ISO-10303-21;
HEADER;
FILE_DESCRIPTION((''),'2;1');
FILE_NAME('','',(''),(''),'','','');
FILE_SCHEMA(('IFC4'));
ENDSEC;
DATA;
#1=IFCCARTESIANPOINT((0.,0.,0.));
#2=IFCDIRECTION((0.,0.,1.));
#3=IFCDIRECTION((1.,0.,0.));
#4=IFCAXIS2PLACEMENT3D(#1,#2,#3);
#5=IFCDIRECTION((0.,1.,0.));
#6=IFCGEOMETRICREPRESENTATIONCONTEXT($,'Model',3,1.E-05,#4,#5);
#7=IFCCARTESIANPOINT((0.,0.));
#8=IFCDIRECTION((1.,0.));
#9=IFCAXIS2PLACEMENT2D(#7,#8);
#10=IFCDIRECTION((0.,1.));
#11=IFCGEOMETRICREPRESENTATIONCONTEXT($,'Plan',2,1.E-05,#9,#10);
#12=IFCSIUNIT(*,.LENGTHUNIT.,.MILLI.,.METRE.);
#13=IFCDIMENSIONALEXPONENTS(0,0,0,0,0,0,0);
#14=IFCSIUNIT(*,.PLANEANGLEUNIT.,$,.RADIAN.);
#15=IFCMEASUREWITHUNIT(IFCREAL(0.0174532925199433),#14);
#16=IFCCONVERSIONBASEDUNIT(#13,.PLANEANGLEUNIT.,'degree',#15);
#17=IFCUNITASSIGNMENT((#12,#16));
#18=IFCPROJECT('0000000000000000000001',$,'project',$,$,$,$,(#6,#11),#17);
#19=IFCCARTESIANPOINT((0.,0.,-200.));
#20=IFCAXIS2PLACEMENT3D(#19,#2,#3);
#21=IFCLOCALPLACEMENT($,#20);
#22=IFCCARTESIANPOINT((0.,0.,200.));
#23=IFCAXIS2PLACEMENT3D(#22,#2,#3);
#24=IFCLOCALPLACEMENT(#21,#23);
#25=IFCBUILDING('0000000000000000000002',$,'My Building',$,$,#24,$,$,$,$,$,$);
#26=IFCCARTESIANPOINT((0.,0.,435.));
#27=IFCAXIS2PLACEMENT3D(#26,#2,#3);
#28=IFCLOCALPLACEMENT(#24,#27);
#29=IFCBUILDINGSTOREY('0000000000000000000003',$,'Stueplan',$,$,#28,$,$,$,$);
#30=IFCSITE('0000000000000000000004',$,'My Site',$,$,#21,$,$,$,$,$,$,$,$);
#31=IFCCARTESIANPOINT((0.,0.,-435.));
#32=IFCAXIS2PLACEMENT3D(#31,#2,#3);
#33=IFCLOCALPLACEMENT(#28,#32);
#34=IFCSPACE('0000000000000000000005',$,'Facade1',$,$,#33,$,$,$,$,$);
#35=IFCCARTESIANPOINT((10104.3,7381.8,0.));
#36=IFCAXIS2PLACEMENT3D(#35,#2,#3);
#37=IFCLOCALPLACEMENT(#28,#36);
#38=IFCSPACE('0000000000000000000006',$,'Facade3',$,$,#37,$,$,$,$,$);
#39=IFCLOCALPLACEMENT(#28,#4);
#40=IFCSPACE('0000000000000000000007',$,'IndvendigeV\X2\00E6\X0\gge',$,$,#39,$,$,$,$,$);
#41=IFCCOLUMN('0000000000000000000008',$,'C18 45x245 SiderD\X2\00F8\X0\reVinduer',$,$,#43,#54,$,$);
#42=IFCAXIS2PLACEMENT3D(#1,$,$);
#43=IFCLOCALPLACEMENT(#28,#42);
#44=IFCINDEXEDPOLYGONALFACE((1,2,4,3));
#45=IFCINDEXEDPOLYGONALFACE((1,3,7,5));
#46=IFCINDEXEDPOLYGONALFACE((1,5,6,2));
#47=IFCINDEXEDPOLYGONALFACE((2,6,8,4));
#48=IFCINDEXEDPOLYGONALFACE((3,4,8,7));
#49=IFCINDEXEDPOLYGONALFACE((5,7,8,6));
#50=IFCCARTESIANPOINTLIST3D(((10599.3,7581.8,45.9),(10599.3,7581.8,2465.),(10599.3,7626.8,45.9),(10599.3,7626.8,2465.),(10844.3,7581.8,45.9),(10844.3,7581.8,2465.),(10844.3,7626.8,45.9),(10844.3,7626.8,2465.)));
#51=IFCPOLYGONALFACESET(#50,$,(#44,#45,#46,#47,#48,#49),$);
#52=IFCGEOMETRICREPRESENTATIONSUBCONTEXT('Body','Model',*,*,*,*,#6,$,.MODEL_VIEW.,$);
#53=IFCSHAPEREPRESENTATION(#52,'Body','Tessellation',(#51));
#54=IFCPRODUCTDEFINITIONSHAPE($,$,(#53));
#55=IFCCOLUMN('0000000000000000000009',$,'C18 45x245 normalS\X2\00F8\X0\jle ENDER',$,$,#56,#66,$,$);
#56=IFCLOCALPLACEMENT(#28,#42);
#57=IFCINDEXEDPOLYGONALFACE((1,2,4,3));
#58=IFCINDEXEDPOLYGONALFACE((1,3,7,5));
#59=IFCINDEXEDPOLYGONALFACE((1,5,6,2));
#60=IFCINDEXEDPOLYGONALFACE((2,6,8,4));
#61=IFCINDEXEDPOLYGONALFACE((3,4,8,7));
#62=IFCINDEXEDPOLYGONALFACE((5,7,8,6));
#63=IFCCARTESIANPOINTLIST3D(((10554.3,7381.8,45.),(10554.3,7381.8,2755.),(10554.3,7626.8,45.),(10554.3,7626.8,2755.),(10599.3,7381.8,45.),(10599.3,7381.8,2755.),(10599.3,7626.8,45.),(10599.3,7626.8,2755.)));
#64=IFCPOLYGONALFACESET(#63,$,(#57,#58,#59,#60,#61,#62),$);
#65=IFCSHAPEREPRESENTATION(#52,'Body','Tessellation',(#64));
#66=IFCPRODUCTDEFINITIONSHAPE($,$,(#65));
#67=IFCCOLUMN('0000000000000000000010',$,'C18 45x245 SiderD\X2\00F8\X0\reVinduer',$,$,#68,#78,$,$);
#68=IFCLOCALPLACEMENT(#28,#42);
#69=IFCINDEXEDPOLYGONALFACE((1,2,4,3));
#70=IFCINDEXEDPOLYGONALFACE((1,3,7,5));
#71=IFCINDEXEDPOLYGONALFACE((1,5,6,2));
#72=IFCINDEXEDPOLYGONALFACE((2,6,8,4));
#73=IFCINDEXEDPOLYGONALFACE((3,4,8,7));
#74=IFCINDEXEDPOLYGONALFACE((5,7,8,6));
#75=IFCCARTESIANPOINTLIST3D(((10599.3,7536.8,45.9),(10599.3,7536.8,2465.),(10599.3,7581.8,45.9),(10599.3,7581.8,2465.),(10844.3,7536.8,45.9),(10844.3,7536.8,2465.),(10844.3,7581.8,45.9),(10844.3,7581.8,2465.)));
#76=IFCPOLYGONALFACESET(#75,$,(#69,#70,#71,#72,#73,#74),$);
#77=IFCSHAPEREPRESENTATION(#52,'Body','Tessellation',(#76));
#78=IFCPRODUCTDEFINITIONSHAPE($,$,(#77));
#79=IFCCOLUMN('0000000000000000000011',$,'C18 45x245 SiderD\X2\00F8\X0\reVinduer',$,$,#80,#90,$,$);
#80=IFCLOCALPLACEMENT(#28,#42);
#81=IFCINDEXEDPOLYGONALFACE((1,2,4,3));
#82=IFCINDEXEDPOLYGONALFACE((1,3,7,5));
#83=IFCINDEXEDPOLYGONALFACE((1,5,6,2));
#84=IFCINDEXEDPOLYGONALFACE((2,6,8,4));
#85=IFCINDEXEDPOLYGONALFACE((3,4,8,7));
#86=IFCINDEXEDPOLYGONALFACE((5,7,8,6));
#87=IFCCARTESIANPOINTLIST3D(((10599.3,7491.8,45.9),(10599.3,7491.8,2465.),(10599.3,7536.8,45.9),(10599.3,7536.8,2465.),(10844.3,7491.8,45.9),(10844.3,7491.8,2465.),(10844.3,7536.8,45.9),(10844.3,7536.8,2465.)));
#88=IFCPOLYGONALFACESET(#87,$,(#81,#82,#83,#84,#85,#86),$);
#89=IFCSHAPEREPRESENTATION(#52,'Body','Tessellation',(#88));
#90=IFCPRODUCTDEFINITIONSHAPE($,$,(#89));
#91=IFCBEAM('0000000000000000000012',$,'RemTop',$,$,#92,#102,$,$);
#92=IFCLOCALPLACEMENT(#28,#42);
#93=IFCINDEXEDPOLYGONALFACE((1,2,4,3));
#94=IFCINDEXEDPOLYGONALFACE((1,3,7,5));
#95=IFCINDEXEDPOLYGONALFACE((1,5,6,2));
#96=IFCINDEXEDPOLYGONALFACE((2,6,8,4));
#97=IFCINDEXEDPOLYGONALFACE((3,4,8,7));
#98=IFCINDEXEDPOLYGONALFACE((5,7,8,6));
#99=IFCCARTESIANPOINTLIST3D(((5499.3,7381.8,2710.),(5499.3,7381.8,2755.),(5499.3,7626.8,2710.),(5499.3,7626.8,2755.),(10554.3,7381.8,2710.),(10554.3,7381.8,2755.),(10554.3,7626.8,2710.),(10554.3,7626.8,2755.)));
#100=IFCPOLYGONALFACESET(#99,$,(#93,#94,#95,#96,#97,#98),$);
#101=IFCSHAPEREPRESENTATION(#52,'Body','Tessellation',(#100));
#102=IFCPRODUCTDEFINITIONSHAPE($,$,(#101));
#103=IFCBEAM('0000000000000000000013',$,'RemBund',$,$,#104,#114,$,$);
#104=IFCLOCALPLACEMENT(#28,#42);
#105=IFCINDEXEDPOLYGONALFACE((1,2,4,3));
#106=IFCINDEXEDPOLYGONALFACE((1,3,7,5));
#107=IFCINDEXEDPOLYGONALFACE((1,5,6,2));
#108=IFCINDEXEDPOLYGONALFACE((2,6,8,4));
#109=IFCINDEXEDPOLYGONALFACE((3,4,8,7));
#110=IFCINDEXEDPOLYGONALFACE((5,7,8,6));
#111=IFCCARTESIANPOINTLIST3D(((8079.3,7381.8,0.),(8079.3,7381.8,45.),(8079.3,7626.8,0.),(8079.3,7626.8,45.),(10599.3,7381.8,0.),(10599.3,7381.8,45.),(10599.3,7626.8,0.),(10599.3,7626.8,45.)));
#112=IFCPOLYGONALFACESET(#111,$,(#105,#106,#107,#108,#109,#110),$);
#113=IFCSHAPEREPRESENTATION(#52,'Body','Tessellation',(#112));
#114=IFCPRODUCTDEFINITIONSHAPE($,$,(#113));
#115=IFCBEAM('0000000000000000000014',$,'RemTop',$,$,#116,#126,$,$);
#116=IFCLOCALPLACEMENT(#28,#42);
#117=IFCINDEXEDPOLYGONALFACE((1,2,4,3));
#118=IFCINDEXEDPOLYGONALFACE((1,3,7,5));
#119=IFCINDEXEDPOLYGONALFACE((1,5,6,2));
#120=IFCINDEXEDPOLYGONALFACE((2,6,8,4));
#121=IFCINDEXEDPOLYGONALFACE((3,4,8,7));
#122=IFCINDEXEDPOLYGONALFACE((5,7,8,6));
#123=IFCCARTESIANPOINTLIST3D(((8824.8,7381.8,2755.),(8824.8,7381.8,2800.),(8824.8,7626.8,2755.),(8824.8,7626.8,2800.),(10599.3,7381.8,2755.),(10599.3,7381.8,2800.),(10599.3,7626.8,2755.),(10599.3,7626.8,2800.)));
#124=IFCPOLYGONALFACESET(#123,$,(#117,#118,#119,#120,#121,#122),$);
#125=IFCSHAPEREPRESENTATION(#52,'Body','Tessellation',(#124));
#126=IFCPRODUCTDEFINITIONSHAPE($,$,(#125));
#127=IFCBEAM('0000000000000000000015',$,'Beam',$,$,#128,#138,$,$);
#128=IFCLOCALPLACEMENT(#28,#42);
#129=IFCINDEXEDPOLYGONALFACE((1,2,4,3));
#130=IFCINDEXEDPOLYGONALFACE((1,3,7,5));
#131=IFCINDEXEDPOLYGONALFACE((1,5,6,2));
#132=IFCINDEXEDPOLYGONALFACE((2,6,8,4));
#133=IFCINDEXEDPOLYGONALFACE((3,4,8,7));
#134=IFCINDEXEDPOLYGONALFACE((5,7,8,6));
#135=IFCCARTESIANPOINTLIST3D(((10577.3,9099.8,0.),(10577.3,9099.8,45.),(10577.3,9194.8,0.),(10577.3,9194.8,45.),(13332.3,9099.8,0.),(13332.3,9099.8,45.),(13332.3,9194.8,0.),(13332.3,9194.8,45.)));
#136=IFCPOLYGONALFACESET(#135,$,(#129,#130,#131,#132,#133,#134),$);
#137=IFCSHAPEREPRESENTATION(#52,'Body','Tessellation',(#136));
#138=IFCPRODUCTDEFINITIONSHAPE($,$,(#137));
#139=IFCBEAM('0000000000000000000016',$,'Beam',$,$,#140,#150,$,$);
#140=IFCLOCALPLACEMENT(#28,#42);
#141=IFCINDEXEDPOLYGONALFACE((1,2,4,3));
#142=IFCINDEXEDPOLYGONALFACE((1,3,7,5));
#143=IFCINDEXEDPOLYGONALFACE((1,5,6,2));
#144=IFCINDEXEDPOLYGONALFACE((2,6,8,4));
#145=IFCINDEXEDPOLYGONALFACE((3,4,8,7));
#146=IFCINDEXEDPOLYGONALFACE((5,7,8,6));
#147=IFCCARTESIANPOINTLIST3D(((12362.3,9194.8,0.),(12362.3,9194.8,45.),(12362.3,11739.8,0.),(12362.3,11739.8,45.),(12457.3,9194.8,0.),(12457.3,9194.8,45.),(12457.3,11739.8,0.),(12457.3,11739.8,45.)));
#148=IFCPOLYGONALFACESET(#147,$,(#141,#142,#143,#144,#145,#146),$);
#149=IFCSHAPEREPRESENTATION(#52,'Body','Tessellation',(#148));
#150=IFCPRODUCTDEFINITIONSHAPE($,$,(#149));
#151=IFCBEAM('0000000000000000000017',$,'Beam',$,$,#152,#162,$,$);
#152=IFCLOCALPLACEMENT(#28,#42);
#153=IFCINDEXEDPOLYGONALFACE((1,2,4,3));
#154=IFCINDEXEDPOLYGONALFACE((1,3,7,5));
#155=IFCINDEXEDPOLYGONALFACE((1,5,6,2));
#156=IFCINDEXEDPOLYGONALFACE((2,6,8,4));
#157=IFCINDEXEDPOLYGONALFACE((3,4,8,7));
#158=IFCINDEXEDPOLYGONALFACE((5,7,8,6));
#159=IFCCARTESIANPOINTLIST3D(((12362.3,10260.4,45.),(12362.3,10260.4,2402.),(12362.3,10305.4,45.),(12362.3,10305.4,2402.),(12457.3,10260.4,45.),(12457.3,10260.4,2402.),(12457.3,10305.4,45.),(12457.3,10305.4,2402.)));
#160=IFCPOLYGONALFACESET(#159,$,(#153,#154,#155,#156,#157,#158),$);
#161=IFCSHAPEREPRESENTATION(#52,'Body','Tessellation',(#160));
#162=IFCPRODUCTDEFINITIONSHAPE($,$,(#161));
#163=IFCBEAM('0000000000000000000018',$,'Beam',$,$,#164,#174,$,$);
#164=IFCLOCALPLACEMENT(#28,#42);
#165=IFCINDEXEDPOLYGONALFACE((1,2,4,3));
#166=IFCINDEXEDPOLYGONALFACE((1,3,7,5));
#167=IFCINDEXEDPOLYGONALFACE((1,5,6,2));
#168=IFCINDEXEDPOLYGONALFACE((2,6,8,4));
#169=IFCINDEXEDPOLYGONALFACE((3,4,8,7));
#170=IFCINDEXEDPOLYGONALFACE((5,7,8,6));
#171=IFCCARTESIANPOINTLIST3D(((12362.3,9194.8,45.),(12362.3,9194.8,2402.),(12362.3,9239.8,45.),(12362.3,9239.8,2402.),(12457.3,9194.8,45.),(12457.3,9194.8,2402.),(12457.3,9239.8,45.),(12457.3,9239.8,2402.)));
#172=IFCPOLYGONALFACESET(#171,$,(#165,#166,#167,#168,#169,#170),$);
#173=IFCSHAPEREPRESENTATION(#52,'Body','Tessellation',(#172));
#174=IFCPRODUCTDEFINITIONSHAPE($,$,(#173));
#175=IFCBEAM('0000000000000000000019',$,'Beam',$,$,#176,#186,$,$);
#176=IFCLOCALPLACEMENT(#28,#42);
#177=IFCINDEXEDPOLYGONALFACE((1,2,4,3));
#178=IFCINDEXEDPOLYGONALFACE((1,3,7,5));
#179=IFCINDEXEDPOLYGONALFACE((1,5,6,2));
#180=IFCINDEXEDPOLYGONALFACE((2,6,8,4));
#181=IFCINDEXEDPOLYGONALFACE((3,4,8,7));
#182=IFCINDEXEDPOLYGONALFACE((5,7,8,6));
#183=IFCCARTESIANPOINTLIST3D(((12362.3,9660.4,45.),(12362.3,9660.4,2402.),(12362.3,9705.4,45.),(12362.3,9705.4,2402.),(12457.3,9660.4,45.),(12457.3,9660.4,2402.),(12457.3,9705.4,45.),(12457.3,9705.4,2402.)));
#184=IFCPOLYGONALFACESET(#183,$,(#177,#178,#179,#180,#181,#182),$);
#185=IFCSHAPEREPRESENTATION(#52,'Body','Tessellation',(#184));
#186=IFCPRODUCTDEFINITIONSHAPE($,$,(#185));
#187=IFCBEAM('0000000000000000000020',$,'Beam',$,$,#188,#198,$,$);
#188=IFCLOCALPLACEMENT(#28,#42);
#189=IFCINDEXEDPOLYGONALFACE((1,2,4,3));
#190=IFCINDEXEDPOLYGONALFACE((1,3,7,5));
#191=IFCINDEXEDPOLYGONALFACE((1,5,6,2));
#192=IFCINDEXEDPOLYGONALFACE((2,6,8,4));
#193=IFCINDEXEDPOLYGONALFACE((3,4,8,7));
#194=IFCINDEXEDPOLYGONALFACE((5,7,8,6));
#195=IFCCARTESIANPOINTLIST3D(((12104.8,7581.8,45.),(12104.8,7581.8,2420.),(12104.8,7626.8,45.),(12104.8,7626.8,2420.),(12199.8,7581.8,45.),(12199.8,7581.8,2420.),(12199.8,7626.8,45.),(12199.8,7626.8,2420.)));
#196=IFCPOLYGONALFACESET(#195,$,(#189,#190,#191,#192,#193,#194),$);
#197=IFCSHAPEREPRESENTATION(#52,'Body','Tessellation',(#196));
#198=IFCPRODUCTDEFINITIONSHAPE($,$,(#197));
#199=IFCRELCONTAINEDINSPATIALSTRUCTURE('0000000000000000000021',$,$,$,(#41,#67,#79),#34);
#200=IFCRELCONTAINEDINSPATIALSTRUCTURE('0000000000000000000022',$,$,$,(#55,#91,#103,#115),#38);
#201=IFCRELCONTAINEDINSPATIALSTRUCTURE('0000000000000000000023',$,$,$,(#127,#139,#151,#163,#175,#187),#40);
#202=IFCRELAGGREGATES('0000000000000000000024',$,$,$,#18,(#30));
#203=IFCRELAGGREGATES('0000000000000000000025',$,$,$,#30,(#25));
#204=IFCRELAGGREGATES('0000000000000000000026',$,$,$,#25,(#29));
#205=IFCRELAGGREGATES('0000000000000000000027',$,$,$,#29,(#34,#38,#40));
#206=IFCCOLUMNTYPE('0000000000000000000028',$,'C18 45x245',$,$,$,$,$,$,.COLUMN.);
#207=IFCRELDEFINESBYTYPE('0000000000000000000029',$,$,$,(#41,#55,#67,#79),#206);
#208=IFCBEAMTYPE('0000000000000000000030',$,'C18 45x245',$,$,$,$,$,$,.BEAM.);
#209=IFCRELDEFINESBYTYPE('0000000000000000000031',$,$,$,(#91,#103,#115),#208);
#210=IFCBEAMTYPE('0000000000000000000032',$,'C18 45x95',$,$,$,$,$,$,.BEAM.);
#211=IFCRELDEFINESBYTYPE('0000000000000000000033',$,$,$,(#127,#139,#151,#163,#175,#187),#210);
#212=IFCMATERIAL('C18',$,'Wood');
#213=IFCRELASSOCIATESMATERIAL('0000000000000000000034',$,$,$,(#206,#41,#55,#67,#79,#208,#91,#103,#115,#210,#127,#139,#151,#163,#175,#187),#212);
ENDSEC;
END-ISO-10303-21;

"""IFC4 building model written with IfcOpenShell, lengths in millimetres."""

from ifc_helpers import new_model, entity, si_unit, converted_unit, direction, frame, origin_with_axes, origin_2d_with_axis, place, context, subcontext, project, spatial, rectangle, extrude, material, material_profile, profile_set, profile_usage, type_object, element, save


model = new_model("IFC4")

# Units and contexts
model_context = context("Model", 3, precision=1e-05, world=origin_with_axes(), true_north=direction((0.0, 1.0, 0.0)))
plan_context = context("Plan", 2, precision=1e-05, world=origin_2d_with_axis(), true_north=direction((0.0, 1.0)))
body_context_1 = subcontext(model_context, "Body", "Model", "MODEL_VIEW")
ifc_project = project(units=[si_unit("LENGTHUNIT", "METRE", prefix="MILLI"), converted_unit("PLANEANGLEUNIT", "degree", entity("IfcReal", 0.0174532925199433), si_unit("PLANEANGLEUNIT", "RADIAN"), dimensions=[0, 0, 0, 0, 0, 0, 0])], contexts=[model_context, plan_context])

# Site, building, storey, space
site_placement = place(None, frame((0.0, 0.0, -200.0), z_axis=(0.0, 0.0, 1.0), x_axis=(1.0, 0.0, 0.0)))
site = spatial("IfcSite", under=ifc_project, at=site_placement, Name="My Site")
building_placement = place(site_placement, frame((0.0, 0.0, 200.0), z_axis=(0.0, 0.0, 1.0), x_axis=(1.0, 0.0, 0.0)))
building = spatial("IfcBuilding", under=site, at=building_placement, Name="My Building")
storey_placement = place(building_placement, frame((0.0, 0.0, 435.0), z_axis=(0.0, 0.0, 1.0), x_axis=(1.0, 0.0, 0.0)))
storey = spatial("IfcBuildingStorey", under=building, at=storey_placement, Name="Stueplan")
space_1_placement = place(storey_placement, frame((0.0, 0.0, -435.0), z_axis=(0.0, 0.0, 1.0), x_axis=(1.0, 0.0, 0.0)))
space_1 = spatial("IfcSpace", under=storey, at=space_1_placement, Name="Facade1")

# Column
ifc_material = material(Name="C18", Category="Wood")
ifc_material_profile_1 = material_profile(ifc_material, rectangle(XDim=45.0, YDim=245.0))
ifc_profile_set_1 = profile_set([ifc_material_profile_1], Name="woodStructural")
ifc_profile_usage_1 = profile_usage(ifc_profile_set_1, cardinal=9)
column_type = type_object("IfcColumnType", Name="C18 45x245", PredefinedType="COLUMN", material=ifc_profile_set_1)
column_1_placement = place(space_1_placement, frame((10844.3, 7626.8, 480.9), z_axis=(0.0, 0.0, 1.0), x_axis=(0.0, -1.0, 0.0)))
element("IfcColumn", 1, at=column_1_placement, inside=space_1, type_object=column_type, material=ifc_profile_usage_1, Name="C18 45x245 SiderDøreVinduer", context=body_context_1, shape_type="SweptSolid", body=[
    extrude(rectangle(XDim=45.0, YDim=245.0), frame((22.5, -122.5, 0.0), z_axis=(0.0, 0.0, 1.0), x_axis=(1.0, 0.0, 0.0)), (0.0, 0.0, 1.0), 2419.1),
])

# Shared definitions
space_2_placement = place(storey_placement, frame((10104.3, 7381.8, 0.0), z_axis=(0.0, 0.0, 1.0), x_axis=(1.0, 0.0, 0.0)))
space_2 = spatial("IfcSpace", under=storey, at=space_2_placement, Name="Facade3")

# Columns
ifc_profile_usage_2 = profile_usage(ifc_profile_set_1, cardinal=9)
column_2_placement = place(space_2_placement, frame((449.9, 245.0, 45.0), z_axis=(0.0, 0.0, 1.0), x_axis=(1.0, 0.0, 0.0)))
element("IfcColumn", 2, at=column_2_placement, inside=space_2, type_object=column_type, material=ifc_profile_usage_2, Name="C18 45x245 normalSøjle ENDER", context=body_context_1, shape_type="SweptSolid", body=[
    extrude(rectangle(XDim=45.0, YDim=245.0), frame((22.5, -122.5, 0.0), z_axis=(0.0, 0.0, 1.0), x_axis=(1.0, 0.0, 0.0)), (0.0, 0.0, 1.0), 2710.0),
])
ifc_profile_usage_3 = profile_usage(ifc_profile_set_1, cardinal=9)
column_3_placement = place(space_1_placement, frame((10844.3, 7581.8, 480.9), z_axis=(0.0, 0.0, 1.0), x_axis=(0.0, -1.0, 0.0)))
element("IfcColumn", 3, at=column_3_placement, inside=space_1, type_object=column_type, material=ifc_profile_usage_3, Name="C18 45x245 SiderDøreVinduer", context=body_context_1, shape_type="SweptSolid", body=[
    extrude(rectangle(XDim=45.0, YDim=245.0), frame((22.5, -122.5, 0.0), z_axis=(0.0, 0.0, 1.0), x_axis=(1.0, 0.0, 0.0)), (0.0, 0.0, 1.0), 2419.1),
])
ifc_profile_usage_4 = profile_usage(ifc_profile_set_1, cardinal=9)
column_4_placement = place(space_1_placement, frame((10844.3, 7536.8, 480.9), z_axis=(0.0, 0.0, 1.0), x_axis=(0.0, -1.0, 0.0)))
element("IfcColumn", 4, at=column_4_placement, inside=space_1, type_object=column_type, material=ifc_profile_usage_4, Name="C18 45x245 SiderDøreVinduer", context=body_context_1, shape_type="SweptSolid", body=[
    extrude(rectangle(XDim=45.0, YDim=245.0), frame((22.5, -122.5, 0.0), z_axis=(0.0, 0.0, 1.0), x_axis=(1.0, 0.0, 0.0)), (0.0, 0.0, 1.0), 2419.1),
])

# Beams
ifc_material_profile_2 = material_profile(ifc_material, rectangle(XDim=45.0, YDim=245.0), Name="concrete")
ifc_profile_set_2 = profile_set([ifc_material_profile_2], Name="woodStructural")
ifc_profile_usage_5 = profile_usage(ifc_profile_set_2)
beam_type_1 = type_object("IfcBeamType", Name="C18 45x245", PredefinedType="BEAM", material=ifc_profile_set_2)
beam_1_placement = place(space_2_placement, frame((449.9, 122.5, 2732.5), z_axis=(-1.0, 0.0, 0.0), x_axis=(0.0, 0.0, 1.0)))
element("IfcBeam", 5, at=beam_1_placement, inside=space_2, type_object=beam_type_1, material=ifc_profile_usage_5, Name="RemTop", context=body_context_1, shape_type="SweptSolid", body=[
    extrude(rectangle(XDim=45.0, YDim=245.0), origin_with_axes(), (0.0, 0.0, 1.0), 5055.0),
])
ifc_profile_usage_6 = profile_usage(ifc_profile_set_2)
beam_2_placement = place(space_2_placement, frame((494.9, 122.5, 22.5), z_axis=(-1.0, 0.0, 0.0), x_axis=(0.0, 0.0, 1.0)))
element("IfcBeam", 6, at=beam_2_placement, inside=space_2, type_object=beam_type_1, material=ifc_profile_usage_6, Name="RemBund", context=body_context_1, shape_type="SweptSolid", body=[
    extrude(rectangle(XDim=45.0, YDim=245.0), origin_with_axes(), (0.0, 0.0, 1.0), 2520.0),
])
ifc_profile_usage_7 = profile_usage(ifc_profile_set_2)
beam_3_placement = place(space_2_placement, frame((494.9, 122.5, 2777.5), z_axis=(-1.0, 0.0, 0.0), x_axis=(0.0, 0.0, 1.0)))
element("IfcBeam", 7, at=beam_3_placement, inside=space_2, type_object=beam_type_1, material=ifc_profile_usage_7, Name="RemTop", context=body_context_1, shape_type="SweptSolid", body=[
    extrude(rectangle(XDim=45.0, YDim=245.0), origin_with_axes(), (0.0, 0.0, 1.0), 1774.5),
])

# Shared definitions
space_3_placement = place(storey_placement, frame((0.0, 0.0, 0.0), z_axis=(0.0, 0.0, 1.0), x_axis=(1.0, 0.0, 0.0)))
space_3 = spatial("IfcSpace", under=storey, at=space_3_placement, Name="IndvendigeVægge")

# Beams
ifc_material_profile_3 = material_profile(ifc_material, rectangle(XDim=45.0, YDim=95.0))
ifc_profile_set_3 = profile_set([ifc_material_profile_3], Name="woodStructural")
ifc_profile_usage_8 = profile_usage(ifc_profile_set_3, cardinal=5)
beam_type_2 = type_object("IfcBeamType", Name="C18 45x95", PredefinedType="BEAM", material=ifc_profile_set_3)
beam_4_placement = place(space_3_placement, frame((10577.3, 9147.3, 22.5), z_axis=(1.0, 0.0, 0.0), x_axis=(0.0, 0.0, 1.0)))
element("IfcBeam", 8, at=beam_4_placement, inside=space_3, type_object=beam_type_2, material=ifc_profile_usage_8, Name="Beam", context=body_context_1, shape_type="SweptSolid", body=[
    extrude(rectangle(XDim=45.0, YDim=95.0), origin_with_axes(), (0.0, 0.0, 1.0), 2755.0),
])
ifc_profile_usage_9 = profile_usage(ifc_profile_set_3, cardinal=5)
beam_5_placement = place(space_3_placement, frame((12409.8, 9194.8, 22.5), z_axis=(0.0, 1.0, 0.0), x_axis=(0.0, 0.0, 1.0)))
element("IfcBeam", 9, at=beam_5_placement, inside=space_3, type_object=beam_type_2, material=ifc_profile_usage_9, Name="Beam", context=body_context_1, shape_type="SweptSolid", body=[
    extrude(rectangle(XDim=45.0, YDim=95.0), origin_with_axes(), (0.0, 0.0, 1.0), 2545.0),
])
ifc_profile_usage_10 = profile_usage(ifc_profile_set_3)
beam_6_placement = place(space_3_placement, frame((12409.8, 10282.9, 45.0), z_axis=(0.0, 0.0, 1.0), x_axis=(0.0, -1.0, 0.0)))
element("IfcBeam", 10, at=beam_6_placement, inside=space_3, type_object=beam_type_2, material=ifc_profile_usage_10, Name="Beam", context=body_context_1, shape_type="SweptSolid", body=[
    extrude(rectangle(XDim=45.0, YDim=95.0), origin_with_axes(), (0.0, 0.0, 1.0), 2357.0),
])
ifc_profile_usage_11 = profile_usage(ifc_profile_set_3)
beam_7_placement = place(space_3_placement, frame((12409.8, 9217.3, 45.0), z_axis=(0.0, 0.0, 1.0), x_axis=(0.0, -1.0, 0.0)))
element("IfcBeam", 11, at=beam_7_placement, inside=space_3, type_object=beam_type_2, material=ifc_profile_usage_11, Name="Beam", context=body_context_1, shape_type="SweptSolid", body=[
    extrude(rectangle(XDim=45.0, YDim=95.0), origin_with_axes(), (0.0, 0.0, 1.0), 2357.0),
])
ifc_profile_usage_12 = profile_usage(ifc_profile_set_3)
beam_8_placement = place(space_3_placement, frame((12409.8, 9682.9, 45.0), z_axis=(0.0, 0.0, 1.0), x_axis=(0.0, -1.0, 0.0)))
element("IfcBeam", 12, at=beam_8_placement, inside=space_3, type_object=beam_type_2, material=ifc_profile_usage_12, Name="Beam", context=body_context_1, shape_type="SweptSolid", body=[
    extrude(rectangle(XDim=45.0, YDim=95.0), origin_with_axes(), (0.0, 0.0, 1.0), 2357.0),
])
ifc_profile_usage_13 = profile_usage(ifc_profile_set_3)
beam_9_placement = place(space_3_placement, frame((12152.3, 7604.3, 45.0), z_axis=(0.0, 0.0, 1.0), x_axis=(0.0, 1.0, 0.0)))
element("IfcBeam", 13, at=beam_9_placement, inside=space_3, type_object=beam_type_2, material=ifc_profile_usage_13, Name="Beam", context=body_context_1, shape_type="SweptSolid", body=[
    extrude(rectangle(XDim=45.0, YDim=95.0), origin_with_axes(), (0.0, 0.0, 1.0), 2375.0),
])

save(model, "model.ifc")
